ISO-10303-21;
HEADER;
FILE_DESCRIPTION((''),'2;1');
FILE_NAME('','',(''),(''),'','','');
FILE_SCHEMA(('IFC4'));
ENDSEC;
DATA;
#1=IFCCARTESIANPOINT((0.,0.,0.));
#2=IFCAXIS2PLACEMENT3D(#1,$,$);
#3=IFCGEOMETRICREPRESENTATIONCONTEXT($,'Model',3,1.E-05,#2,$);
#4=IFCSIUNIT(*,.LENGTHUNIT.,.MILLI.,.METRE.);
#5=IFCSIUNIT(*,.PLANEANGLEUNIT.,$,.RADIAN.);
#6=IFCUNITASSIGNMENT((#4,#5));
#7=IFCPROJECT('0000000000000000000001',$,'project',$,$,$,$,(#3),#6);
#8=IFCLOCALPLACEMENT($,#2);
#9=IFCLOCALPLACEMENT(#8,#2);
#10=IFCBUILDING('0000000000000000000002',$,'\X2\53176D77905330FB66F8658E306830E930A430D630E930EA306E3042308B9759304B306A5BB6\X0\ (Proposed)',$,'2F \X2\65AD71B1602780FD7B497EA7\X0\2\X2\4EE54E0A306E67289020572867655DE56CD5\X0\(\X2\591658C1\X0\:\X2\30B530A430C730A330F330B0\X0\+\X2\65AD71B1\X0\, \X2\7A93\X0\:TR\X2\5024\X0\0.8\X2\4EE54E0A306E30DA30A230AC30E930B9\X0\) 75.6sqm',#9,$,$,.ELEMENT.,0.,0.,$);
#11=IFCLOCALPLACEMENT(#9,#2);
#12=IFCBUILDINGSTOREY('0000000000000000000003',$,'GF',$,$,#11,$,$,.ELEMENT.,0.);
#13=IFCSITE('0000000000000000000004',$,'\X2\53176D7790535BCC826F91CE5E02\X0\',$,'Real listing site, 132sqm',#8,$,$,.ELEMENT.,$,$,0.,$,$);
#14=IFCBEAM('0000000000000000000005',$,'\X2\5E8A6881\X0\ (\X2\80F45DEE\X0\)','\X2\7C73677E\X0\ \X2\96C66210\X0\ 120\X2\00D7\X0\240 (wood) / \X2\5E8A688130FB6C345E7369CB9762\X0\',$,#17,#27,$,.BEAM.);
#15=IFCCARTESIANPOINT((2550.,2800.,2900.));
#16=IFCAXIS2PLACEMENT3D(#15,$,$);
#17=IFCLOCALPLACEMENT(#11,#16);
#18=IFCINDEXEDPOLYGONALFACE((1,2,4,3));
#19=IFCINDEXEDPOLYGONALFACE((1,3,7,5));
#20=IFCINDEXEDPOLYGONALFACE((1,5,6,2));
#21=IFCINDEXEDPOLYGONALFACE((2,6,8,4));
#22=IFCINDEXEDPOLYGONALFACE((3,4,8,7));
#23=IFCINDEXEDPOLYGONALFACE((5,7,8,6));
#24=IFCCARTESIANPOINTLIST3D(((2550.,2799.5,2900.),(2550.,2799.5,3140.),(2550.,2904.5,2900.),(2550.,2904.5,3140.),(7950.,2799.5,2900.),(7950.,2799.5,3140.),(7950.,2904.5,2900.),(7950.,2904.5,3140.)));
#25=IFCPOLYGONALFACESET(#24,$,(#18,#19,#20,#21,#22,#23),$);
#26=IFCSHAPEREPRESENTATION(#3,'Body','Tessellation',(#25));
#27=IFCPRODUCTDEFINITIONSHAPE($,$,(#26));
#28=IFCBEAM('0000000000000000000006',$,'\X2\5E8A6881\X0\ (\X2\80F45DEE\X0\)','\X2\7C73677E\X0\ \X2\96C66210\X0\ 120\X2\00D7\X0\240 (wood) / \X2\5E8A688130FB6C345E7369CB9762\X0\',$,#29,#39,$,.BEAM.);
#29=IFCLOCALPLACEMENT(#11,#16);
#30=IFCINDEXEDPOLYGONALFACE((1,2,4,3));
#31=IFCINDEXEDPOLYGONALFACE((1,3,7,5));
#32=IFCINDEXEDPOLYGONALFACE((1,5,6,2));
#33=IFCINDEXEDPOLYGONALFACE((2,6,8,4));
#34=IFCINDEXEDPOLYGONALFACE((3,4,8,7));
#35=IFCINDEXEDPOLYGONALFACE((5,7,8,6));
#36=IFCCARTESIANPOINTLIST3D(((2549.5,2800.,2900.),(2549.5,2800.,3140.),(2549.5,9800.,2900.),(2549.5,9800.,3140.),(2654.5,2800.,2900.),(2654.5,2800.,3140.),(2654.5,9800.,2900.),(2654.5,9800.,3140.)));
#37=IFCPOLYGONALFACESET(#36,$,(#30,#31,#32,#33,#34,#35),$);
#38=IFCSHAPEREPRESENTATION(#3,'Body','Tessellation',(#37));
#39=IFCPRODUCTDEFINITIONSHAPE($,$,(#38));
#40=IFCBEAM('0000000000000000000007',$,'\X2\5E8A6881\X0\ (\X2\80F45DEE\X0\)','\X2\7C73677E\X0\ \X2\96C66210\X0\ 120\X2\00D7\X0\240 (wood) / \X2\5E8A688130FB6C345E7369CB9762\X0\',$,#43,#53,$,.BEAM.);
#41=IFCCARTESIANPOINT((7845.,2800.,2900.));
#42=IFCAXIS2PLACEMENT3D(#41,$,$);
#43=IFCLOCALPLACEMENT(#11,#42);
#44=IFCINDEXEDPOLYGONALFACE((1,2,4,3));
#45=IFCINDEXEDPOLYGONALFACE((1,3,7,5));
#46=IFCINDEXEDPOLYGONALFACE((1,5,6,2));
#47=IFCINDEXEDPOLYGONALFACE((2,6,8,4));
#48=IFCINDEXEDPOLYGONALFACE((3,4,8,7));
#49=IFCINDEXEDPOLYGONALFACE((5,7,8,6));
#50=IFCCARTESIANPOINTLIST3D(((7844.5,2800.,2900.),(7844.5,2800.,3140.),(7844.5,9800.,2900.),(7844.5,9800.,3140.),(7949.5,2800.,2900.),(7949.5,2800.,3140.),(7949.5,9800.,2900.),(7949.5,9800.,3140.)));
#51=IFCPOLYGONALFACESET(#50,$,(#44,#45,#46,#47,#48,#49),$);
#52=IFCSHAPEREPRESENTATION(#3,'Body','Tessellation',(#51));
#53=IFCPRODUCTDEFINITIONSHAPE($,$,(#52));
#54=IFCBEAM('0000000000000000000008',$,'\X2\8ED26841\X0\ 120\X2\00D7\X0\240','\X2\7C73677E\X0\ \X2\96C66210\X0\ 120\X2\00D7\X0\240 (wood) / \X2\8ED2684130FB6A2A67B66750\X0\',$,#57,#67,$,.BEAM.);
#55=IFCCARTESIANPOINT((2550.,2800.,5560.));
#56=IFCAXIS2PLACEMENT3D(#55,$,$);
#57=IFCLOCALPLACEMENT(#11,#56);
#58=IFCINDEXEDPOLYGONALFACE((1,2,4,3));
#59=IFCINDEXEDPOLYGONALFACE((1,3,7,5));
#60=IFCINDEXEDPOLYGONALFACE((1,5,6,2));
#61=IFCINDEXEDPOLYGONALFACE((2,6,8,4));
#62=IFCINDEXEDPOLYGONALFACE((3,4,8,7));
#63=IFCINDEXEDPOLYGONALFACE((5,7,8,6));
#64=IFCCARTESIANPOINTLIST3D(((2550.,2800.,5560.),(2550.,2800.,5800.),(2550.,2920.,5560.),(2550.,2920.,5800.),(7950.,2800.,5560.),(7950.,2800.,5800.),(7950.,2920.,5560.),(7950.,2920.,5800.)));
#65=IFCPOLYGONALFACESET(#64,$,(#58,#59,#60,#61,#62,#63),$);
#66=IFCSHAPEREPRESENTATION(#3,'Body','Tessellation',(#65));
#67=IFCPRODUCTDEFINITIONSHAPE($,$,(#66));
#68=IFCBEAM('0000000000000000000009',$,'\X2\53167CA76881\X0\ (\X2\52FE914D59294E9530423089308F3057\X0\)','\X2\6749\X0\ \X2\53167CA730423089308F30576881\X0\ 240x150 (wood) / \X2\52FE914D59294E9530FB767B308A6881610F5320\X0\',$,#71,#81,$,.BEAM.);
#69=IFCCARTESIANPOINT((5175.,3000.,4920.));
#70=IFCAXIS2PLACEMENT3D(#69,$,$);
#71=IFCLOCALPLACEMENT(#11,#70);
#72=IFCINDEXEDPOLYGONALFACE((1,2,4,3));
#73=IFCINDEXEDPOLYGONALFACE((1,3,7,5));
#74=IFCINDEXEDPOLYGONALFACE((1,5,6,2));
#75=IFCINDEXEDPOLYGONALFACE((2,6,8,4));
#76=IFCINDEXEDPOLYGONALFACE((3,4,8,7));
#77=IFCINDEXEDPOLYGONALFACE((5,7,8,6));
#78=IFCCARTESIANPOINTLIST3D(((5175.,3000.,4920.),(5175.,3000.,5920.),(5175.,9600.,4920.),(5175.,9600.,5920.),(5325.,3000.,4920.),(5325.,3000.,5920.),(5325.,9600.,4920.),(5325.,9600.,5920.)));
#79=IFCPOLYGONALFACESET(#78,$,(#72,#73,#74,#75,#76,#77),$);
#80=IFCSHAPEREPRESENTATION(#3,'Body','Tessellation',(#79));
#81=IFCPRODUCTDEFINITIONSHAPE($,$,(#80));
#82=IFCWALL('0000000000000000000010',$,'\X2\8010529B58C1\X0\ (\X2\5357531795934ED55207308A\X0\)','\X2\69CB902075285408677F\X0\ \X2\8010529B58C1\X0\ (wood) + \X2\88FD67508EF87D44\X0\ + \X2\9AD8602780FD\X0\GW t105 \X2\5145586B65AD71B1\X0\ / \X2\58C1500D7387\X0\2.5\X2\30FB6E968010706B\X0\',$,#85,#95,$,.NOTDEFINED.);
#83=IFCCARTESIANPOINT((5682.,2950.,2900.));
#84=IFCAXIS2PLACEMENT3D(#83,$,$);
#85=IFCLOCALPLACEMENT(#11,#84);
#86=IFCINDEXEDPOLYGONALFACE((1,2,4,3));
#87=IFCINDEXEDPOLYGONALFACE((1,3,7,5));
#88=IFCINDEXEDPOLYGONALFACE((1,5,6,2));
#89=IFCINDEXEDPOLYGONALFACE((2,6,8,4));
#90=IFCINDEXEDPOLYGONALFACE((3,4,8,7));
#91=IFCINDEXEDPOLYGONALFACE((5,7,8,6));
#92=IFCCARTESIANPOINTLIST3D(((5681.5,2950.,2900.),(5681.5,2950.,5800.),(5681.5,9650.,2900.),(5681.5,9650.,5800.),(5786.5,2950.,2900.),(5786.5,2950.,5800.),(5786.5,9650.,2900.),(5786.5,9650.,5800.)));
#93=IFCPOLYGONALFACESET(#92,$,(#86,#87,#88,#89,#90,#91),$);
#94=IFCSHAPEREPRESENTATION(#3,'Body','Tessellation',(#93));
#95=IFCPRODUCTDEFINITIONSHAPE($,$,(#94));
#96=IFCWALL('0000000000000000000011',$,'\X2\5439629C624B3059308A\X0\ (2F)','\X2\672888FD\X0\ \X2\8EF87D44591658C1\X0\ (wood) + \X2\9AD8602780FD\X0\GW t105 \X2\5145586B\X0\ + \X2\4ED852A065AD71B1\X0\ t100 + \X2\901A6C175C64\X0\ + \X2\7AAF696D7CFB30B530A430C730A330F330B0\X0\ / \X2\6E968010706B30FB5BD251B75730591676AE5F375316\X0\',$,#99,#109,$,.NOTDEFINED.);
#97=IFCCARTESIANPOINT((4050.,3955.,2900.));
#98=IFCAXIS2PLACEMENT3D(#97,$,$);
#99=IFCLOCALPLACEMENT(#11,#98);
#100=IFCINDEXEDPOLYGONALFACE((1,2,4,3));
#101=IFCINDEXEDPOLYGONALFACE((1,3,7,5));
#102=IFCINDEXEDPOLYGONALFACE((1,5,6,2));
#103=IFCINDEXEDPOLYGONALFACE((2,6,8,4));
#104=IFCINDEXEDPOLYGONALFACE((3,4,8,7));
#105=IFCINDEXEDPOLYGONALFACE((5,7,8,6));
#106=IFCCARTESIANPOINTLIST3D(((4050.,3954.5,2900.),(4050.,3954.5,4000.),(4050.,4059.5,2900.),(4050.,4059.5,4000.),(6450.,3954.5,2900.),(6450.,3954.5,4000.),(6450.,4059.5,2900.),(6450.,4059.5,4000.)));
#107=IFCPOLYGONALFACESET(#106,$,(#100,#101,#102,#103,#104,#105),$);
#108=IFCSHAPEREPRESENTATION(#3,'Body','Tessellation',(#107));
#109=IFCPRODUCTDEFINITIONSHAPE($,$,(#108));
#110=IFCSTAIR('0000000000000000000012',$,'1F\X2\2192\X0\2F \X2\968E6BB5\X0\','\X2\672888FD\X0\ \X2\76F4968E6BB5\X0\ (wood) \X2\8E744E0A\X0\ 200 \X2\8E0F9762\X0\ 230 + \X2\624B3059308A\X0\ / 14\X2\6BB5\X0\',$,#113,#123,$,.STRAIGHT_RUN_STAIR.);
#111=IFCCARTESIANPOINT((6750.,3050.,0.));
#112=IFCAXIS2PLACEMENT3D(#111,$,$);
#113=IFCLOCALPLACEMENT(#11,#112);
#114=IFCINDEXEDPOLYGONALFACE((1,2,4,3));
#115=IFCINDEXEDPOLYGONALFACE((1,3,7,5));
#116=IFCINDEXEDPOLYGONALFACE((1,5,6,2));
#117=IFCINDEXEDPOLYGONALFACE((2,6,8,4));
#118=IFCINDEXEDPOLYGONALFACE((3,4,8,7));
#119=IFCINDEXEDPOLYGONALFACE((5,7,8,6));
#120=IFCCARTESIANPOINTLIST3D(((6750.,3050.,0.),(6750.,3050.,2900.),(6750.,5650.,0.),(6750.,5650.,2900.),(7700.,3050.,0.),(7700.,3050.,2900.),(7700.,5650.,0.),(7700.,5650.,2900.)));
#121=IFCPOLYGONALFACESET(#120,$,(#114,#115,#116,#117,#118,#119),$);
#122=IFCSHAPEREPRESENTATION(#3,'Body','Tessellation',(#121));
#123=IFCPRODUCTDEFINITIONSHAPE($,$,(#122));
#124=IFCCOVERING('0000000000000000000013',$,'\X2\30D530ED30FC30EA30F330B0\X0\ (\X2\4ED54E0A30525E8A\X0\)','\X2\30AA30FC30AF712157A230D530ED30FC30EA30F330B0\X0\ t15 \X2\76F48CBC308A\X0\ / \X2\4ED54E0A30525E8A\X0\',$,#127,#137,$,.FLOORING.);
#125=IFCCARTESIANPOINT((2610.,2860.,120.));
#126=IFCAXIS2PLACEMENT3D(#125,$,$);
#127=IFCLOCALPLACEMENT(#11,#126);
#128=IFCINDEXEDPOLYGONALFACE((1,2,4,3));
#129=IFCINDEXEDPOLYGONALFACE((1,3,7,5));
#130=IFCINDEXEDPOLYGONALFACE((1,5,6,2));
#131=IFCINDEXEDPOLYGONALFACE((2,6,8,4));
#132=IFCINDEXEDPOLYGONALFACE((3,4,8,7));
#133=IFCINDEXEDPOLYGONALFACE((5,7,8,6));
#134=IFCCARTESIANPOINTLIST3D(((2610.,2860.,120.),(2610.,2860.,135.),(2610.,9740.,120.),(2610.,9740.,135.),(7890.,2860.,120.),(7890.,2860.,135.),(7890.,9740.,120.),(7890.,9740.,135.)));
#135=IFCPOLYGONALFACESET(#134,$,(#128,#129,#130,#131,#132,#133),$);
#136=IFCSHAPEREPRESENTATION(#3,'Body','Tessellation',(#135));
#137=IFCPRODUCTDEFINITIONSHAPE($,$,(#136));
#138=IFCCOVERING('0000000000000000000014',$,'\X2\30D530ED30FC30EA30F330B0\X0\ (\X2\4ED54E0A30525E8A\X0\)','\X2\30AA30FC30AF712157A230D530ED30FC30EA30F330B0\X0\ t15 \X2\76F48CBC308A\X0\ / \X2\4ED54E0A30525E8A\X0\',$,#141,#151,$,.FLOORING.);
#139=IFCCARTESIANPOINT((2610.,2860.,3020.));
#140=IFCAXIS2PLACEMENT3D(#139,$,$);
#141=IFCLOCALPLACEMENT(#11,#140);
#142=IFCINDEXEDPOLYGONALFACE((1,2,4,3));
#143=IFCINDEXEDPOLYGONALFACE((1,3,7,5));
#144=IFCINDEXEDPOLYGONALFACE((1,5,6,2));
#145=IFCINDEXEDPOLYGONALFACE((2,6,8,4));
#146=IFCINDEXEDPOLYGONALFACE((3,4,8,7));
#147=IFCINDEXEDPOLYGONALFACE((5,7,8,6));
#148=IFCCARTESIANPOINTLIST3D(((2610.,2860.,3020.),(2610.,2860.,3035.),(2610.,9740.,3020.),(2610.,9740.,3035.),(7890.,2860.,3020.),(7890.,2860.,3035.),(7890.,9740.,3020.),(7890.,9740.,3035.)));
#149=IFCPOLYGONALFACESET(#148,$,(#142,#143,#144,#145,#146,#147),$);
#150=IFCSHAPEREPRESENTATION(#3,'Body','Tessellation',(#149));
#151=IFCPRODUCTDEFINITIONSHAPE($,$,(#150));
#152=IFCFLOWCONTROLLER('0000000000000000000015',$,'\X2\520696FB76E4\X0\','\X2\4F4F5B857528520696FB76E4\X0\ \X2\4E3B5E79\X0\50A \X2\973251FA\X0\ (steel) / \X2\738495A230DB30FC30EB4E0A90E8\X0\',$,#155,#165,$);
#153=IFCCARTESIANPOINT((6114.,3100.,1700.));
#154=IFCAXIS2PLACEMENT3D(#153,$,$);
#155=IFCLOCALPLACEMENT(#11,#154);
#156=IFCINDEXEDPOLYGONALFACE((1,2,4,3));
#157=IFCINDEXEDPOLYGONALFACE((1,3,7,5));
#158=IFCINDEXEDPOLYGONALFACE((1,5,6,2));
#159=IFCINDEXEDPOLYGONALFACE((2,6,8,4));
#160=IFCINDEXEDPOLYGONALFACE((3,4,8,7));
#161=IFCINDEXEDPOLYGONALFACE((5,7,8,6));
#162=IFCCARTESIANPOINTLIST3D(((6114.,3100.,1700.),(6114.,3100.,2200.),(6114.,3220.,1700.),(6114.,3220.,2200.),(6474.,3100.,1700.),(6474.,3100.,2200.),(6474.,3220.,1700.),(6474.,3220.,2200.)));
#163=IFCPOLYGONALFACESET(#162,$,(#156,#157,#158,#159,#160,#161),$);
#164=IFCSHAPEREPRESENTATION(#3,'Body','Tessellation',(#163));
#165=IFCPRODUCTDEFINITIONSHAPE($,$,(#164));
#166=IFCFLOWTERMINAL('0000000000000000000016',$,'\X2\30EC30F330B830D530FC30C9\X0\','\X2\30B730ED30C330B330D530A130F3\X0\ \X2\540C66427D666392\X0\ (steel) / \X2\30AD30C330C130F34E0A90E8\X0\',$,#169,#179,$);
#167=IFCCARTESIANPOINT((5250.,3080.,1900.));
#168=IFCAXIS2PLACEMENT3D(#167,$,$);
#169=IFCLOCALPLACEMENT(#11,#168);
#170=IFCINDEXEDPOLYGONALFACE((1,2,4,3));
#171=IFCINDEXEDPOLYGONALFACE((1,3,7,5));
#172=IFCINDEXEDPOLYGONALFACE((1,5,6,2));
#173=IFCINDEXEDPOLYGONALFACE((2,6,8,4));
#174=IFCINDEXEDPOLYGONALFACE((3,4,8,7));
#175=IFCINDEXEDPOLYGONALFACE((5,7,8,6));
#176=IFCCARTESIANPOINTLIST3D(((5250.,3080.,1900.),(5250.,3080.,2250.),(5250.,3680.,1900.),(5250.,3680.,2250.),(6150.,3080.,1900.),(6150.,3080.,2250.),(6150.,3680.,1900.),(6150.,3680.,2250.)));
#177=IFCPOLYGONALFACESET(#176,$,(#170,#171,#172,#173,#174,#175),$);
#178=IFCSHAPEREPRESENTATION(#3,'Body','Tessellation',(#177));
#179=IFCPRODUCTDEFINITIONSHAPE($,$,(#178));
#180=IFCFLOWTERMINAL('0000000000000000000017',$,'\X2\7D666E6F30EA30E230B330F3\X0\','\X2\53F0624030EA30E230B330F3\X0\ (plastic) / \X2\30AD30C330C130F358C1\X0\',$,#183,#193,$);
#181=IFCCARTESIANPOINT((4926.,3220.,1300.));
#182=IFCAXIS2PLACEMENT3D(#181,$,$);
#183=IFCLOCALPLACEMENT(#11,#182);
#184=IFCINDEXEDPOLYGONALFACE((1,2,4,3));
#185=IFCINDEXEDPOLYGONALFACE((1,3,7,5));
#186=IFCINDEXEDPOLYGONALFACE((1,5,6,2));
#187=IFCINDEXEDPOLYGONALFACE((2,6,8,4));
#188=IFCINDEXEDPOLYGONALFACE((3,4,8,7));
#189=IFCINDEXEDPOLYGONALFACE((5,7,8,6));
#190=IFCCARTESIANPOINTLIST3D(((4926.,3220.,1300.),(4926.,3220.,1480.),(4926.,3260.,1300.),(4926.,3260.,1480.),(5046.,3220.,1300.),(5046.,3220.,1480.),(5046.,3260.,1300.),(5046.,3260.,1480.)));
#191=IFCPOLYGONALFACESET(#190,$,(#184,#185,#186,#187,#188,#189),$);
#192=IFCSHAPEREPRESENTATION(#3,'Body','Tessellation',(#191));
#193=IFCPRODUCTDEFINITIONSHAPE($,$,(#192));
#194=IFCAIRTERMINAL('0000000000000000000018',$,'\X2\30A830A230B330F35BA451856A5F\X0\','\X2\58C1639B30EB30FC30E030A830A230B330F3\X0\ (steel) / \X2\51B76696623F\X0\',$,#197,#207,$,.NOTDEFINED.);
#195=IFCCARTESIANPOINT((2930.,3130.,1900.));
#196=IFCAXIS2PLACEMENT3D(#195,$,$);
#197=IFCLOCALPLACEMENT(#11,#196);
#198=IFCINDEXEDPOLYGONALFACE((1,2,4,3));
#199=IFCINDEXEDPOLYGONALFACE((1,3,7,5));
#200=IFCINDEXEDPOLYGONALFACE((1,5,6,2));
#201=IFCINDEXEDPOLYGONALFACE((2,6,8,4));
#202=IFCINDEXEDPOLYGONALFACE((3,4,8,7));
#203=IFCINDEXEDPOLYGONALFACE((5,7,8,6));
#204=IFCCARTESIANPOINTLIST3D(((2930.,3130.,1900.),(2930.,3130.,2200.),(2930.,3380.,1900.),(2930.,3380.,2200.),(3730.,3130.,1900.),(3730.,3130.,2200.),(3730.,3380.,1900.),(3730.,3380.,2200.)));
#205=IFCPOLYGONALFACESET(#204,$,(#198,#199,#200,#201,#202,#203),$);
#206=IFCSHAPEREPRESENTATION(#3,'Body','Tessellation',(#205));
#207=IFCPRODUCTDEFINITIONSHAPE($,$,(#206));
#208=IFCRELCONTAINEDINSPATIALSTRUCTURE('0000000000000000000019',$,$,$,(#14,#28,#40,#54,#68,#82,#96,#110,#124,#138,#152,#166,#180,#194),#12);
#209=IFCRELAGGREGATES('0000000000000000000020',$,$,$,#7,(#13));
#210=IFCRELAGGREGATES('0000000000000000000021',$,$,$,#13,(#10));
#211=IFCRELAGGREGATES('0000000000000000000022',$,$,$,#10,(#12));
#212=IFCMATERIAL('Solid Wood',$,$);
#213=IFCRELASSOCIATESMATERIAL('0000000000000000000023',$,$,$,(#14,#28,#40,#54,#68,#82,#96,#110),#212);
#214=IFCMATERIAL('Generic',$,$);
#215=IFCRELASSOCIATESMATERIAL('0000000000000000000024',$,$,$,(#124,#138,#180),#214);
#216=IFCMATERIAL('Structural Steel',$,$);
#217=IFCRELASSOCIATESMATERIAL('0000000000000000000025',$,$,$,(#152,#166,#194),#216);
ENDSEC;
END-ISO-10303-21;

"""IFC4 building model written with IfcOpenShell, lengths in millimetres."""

from ifc_helpers import new_model, si_unit, frame, frame_2d, origin, place, context, project, spatial, rectangle, extrude, material, element, save


model = new_model("IFC4")

# Units and contexts
model_context = context("Model", 3, precision=1e-05, world=origin())
ifc_project = project(units=[si_unit("LENGTHUNIT", "METRE", prefix="MILLI"), si_unit("PLANEANGLEUNIT", "RADIAN")], contexts=[model_context])

# Site, building, storey
site_placement = place(None, origin())
site = spatial("IfcSite", under=ifc_project, at=site_placement, Name="北海道富良野市", ObjectType="Real listing site, 132sqm", CompositionType="ELEMENT", RefElevation=0.0)
building_placement = place(site_placement, origin())
building = spatial("IfcBuilding", under=site, at=building_placement, Name="北海道・書斎とライブラリのある静かな家 (Proposed)", ObjectType="2F 断熱性能等级2以上の木造在来工法(外壁:サイディング+断熱, 窓:TR値0.8以上のペアガラス) 75.6sqm", CompositionType="ELEMENT", ElevationOfRefHeight=0.0, ElevationOfTerrain=0.0)
storey_placement = place(building_placement, origin())
storey = spatial("IfcBuildingStorey", under=building, at=storey_placement, Name="GF", CompositionType="ELEMENT", Elevation=0.0)

# Beams
ifc_material_1 = material(Name="Solid Wood")
beam_1_placement = place(storey_placement, frame((2550.0, 2800.0, 2900.0)))
element("IfcBeam", 1, at=beam_1_placement, inside=storey, material=ifc_material_1, Name="床梁 (胴差)", Description="米松 集成 120×240 (wood) / 床梁・水平構面", PredefinedType="BEAM", context=model_context, shape_type="SweptSolid", body=[
    extrude(rectangle(XDim=5400.0, YDim=105.0, at=frame_2d((2700.0, 52.0))), frame((2550.0, 2800.0, 2900.0)), (0.0, 0.0, 1.0), 240.0),
])
beam_2_placement = place(storey_placement, frame((2550.0, 2800.0, 2900.0)))
element("IfcBeam", 2, at=beam_2_placement, inside=storey, material=ifc_material_1, Name="床梁 (胴差)", Description="米松 集成 120×240 (wood) / 床梁・水平構面", PredefinedType="BEAM", context=model_context, shape_type="SweptSolid", body=[
    extrude(rectangle(XDim=105.0, YDim=7000.0, at=frame_2d((52.0, 3500.0))), frame((2550.0, 2800.0, 2900.0)), (0.0, 0.0, 1.0), 240.0),
])
beam_3_placement = place(storey_placement, frame((7845.0, 2800.0, 2900.0)))
element("IfcBeam", 3, at=beam_3_placement, inside=storey, material=ifc_material_1, Name="床梁 (胴差)", Description="米松 集成 120×240 (wood) / 床梁・水平構面", PredefinedType="BEAM", context=model_context, shape_type="SweptSolid", body=[
    extrude(rectangle(XDim=105.0, YDim=7000.0, at=frame_2d((52.0, 3500.0))), frame((7845.0, 2800.0, 2900.0)), (0.0, 0.0, 1.0), 240.0),
])
beam_4_placement = place(storey_placement, frame((2550.0, 2800.0, 5560.0)))
element("IfcBeam", 4, at=beam_4_placement, inside=storey, material=ifc_material_1, Name="軒桁 120×240", Description="米松 集成 120×240 (wood) / 軒桁・横架材", PredefinedType="BEAM", context=model_context, shape_type="SweptSolid", body=[
    extrude(rectangle(XDim=5400.0, YDim=120.0, at=frame_2d((2700.0, 60.0))), frame((2550.0, 2800.0, 5560.0)), (0.0, 0.0, 1.0), 240.0),
])
beam_5_placement = place(storey_placement, frame((5175.0, 3000.0, 4920.0)))
element("IfcBeam", 5, at=beam_5_placement, inside=storey, material=ifc_material_1, Name="化粧梁 (勾配天井あらわし)", Description="杉 化粧あらわし梁 240x150 (wood) / 勾配天井・登り梁意匠", PredefinedType="BEAM", context=model_context, shape_type="SweptSolid", body=[
    extrude(rectangle(XDim=150.0, YDim=6600.0, at=frame_2d((75.0, 3300.0))), frame((5175.0, 3000.0, 4920.0)), (0.0, 0.0, 1.0), 1000.0),
])

# Walls
wall_1_placement = place(storey_placement, frame((5682.0, 2950.0, 2900.0)))
element("IfcWall", 6, at=wall_1_placement, inside=storey, material=ifc_material_1, Name="耐力壁 (南北間仕切り)", Description="構造用合板 耐力壁 (wood) + 製材軸組 + 高性能GW t105 充填断熱 / 壁倍率2.5・準耐火", PredefinedType="NOTDEFINED", context=model_context, shape_type="SweptSolid", body=[
    extrude(rectangle(XDim=105.0, YDim=6700.0, at=frame_2d((52.0, 3350.0))), frame((5682.0, 2950.0, 2900.0)), (0.0, 0.0, 1.0), 2900.0),
])
wall_2_placement = place(storey_placement, frame((4050.0, 3955.0, 2900.0)))
element("IfcWall", 7, at=wall_2_placement, inside=storey, material=ifc_material_1, Name="吹抜手すり (2F)", Description="木製 軸組外壁 (wood) + 高性能GW t105 充填 + 付加断熱 t100 + 通気層 + 窯業系サイディング / 準耐火・寒冷地外皮強化", PredefinedType="NOTDEFINED", context=model_context, shape_type="SweptSolid", body=[
    extrude(rectangle(XDim=2400.0, YDim=105.0, at=frame_2d((1200.0, 52.0))), frame((4050.0, 3955.0, 2900.0)), (0.0, 0.0, 1.0), 1100.0),
])

# Stair
stair_placement = place(storey_placement, frame((6750.0, 3050.0, 0.0)))
element("IfcStair", 8, at=stair_placement, inside=storey, material=ifc_material_1, Name="1F→2F 階段", Description="木製 直階段 (wood) 蹴上 200 踏面 230 + 手すり / 14段", PredefinedType="STRAIGHT_RUN_STAIR", context=model_context, shape_type="SweptSolid", body=[
    extrude(rectangle(XDim=950.0, YDim=2600.0, at=frame_2d((475.0, 1300.0))), frame((6750.0, 3050.0, 0.0)), (0.0, 0.0, 1.0), 2900.0),
])

# Coverings
ifc_material_2 = material(Name="Generic")
covering_1_placement = place(storey_placement, frame((2610.0, 2860.0, 120.0)))
element("IfcCovering", 9, at=covering_1_placement, inside=storey, material=ifc_material_2, Name="フローリング (仕上げ床)", Description="オーク無垢フローリング t15 直貼り / 仕上げ床", PredefinedType="FLOORING", context=model_context, shape_type="SweptSolid", body=[
    extrude(rectangle(XDim=5280.0, YDim=6880.0, at=frame_2d((2640.0, 3440.0))), frame((2610.0, 2860.0, 120.0)), (0.0, 0.0, 1.0), 15.0),
])
covering_2_placement = place(storey_placement, frame((2610.0, 2860.0, 3020.0)))
element("IfcCovering", 10, at=covering_2_placement, inside=storey, material=ifc_material_2, Name="フローリング (仕上げ床)", Description="オーク無垢フローリング t15 直貼り / 仕上げ床", PredefinedType="FLOORING", context=model_context, shape_type="SweptSolid", body=[
    extrude(rectangle(XDim=5280.0, YDim=6880.0, at=frame_2d((2640.0, 3440.0))), frame((2610.0, 2860.0, 3020.0)), (0.0, 0.0, 1.0), 15.0),
])

# Flow controller
ifc_material_3 = material(Name="Structural Steel")
flow_controller_placement = place(storey_placement, frame((6114.0, 3100.0, 1700.0)))
element("IfcFlowController", 11, at=flow_controller_placement, inside=storey, material=ifc_material_3, Name="分電盤", Description="住宅用分電盤 主幹50A 露出 (steel) / 玄関ホール上部", context=model_context, shape_type="SweptSolid", body=[
    extrude(rectangle(XDim=360.0, YDim=120.0, at=frame_2d((180.0, 60.0))), frame((6114.0, 3100.0, 1700.0)), (0.0, 0.0, 1.0), 500.0),
])

# Flow terminals
flow_terminal_1_placement = place(storey_placement, frame((5250.0, 3080.0, 1900.0)))
element("IfcFlowTerminal", 12, at=flow_terminal_1_placement, inside=storey, material=ifc_material_3, Name="レンジフード", Description="シロッコファン 同時給排 (steel) / キッチン上部", context=model_context, shape_type="SweptSolid", body=[
    extrude(rectangle(XDim=900.0, YDim=600.0, at=frame_2d((450.0, 300.0))), frame((5250.0, 3080.0, 1900.0)), (0.0, 0.0, 1.0), 350.0),
])
flow_terminal_2_placement = place(storey_placement, frame((4926.0, 3220.0, 1300.0)))
element("IfcFlowTerminal", 13, at=flow_terminal_2_placement, inside=storey, material=ifc_material_2, Name="給湯リモコン", Description="台所リモコン (plastic) / キッチン壁", context=model_context, shape_type="SweptSolid", body=[
    extrude(rectangle(XDim=120.0, YDim=40.0, at=frame_2d((60.0, 20.0))), frame((4926.0, 3220.0, 1300.0)), (0.0, 0.0, 1.0), 180.0),
])

# Air terminal
air_terminal_1_placement = place(storey_placement, frame((2930.0, 3130.0, 1900.0)))
element("IfcAirTerminal", 14, at=air_terminal_1_placement, inside=storey, material=ifc_material_3, Name="エアコン室内機", Description="壁掛ルームエアコン (steel) / 冷暖房", PredefinedType="NOTDEFINED", context=model_context, shape_type="SweptSolid", body=[
    extrude(rectangle(XDim=800.0, YDim=250.0, at=frame_2d((400.0, 125.0))), frame((2930.0, 3130.0, 1900.0)), (0.0, 0.0, 1.0), 300.0),
])

save(model, "model.ifc")
